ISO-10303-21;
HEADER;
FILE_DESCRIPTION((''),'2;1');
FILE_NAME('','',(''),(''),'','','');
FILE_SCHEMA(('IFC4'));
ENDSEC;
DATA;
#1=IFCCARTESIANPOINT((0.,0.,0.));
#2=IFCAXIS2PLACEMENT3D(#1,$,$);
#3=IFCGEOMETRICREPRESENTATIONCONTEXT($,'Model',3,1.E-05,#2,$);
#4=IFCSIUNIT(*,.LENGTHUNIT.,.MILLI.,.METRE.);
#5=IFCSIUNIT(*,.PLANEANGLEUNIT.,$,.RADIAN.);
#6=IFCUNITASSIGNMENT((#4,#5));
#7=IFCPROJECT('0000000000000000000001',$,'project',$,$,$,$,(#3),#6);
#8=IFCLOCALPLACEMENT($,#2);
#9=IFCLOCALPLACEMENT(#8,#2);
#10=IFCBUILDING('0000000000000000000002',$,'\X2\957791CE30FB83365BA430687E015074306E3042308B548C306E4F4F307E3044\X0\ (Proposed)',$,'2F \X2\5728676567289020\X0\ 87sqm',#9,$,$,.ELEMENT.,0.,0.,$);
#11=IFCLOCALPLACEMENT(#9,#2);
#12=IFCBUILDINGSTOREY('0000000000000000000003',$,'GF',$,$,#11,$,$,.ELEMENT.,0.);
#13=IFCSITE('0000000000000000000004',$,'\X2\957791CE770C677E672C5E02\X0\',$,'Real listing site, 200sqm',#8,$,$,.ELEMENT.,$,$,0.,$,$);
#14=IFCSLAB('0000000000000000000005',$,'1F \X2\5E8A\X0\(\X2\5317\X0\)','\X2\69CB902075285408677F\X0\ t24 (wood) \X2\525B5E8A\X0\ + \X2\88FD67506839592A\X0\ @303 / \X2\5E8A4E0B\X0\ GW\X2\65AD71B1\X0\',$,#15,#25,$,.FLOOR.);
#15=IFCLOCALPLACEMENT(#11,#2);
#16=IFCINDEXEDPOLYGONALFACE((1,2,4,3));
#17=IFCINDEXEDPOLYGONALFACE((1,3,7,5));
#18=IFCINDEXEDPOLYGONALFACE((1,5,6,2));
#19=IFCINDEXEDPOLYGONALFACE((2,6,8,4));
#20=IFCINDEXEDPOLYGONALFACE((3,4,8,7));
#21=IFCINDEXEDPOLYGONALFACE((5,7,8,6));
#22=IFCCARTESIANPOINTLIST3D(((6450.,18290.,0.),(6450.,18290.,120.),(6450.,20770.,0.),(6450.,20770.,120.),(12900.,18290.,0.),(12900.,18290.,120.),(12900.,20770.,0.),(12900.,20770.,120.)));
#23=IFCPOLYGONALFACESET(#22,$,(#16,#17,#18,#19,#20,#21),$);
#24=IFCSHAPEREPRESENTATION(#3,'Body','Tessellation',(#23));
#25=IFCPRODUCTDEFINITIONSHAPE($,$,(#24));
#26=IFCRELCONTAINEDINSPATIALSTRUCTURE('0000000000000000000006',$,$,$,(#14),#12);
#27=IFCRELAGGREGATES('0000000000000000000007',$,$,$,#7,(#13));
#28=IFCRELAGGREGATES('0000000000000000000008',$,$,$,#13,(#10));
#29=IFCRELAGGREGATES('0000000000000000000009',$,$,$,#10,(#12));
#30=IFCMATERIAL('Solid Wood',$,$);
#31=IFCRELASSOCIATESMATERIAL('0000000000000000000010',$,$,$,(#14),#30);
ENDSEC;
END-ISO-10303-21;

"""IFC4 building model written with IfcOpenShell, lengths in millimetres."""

from ifc_helpers import new_model, si_unit, frame, frame_2d, origin, place, context, project, spatial, rectangle, extrude, material, element, save


model = new_model("IFC4")

# Units and contexts
model_context = context("Model", 3, precision=1e-05, world=origin())
ifc_project = project(units=[si_unit("LENGTHUNIT", "METRE", prefix="MILLI"), si_unit("PLANEANGLEUNIT", "RADIAN")], contexts=[model_context])

# Site, building, storey
site_placement = place(None, origin())
site = spatial("IfcSite", under=ifc_project, at=site_placement, Name="長野県松本市", ObjectType="Real listing site, 200sqm", CompositionType="ELEMENT", RefElevation=0.0)
building_placement = place(site_placement, origin())
building = spatial("IfcBuilding", under=site, at=building_placement, Name="長野・茶室と縁側のある和の住まい (Proposed)", ObjectType="2F 在来木造 87sqm", CompositionType="ELEMENT", ElevationOfRefHeight=0.0, ElevationOfTerrain=0.0)
storey_placement = place(building_placement, origin())
storey = spatial("IfcBuildingStorey", under=building, at=storey_placement, Name="GF", CompositionType="ELEMENT", Elevation=0.0)

# Shared definitions
ifc_material_1 = material(Name="Solid Wood")

# Slab
slab_placement = place(storey_placement, frame((3225.0, 9145.0, 0.0)))
element("IfcSlab", 1, at=slab_placement, inside=storey, material=ifc_material_1, Name="1F 床(北)", Description="構造用合板 t24 (wood) 剛床 + 製材根太 @303 / 床下 GW断熱", PredefinedType="FLOOR", context=model_context, shape_type="SweptSolid", body=[
    extrude(rectangle(XDim=6450.0, YDim=2480.0, at=frame_2d((3225.0, 1240.0))), frame((3225.0, 9145.0, 0.0)), (0.0, 0.0, 1.0), 120.0),
])

save(model, "model.ifc")
